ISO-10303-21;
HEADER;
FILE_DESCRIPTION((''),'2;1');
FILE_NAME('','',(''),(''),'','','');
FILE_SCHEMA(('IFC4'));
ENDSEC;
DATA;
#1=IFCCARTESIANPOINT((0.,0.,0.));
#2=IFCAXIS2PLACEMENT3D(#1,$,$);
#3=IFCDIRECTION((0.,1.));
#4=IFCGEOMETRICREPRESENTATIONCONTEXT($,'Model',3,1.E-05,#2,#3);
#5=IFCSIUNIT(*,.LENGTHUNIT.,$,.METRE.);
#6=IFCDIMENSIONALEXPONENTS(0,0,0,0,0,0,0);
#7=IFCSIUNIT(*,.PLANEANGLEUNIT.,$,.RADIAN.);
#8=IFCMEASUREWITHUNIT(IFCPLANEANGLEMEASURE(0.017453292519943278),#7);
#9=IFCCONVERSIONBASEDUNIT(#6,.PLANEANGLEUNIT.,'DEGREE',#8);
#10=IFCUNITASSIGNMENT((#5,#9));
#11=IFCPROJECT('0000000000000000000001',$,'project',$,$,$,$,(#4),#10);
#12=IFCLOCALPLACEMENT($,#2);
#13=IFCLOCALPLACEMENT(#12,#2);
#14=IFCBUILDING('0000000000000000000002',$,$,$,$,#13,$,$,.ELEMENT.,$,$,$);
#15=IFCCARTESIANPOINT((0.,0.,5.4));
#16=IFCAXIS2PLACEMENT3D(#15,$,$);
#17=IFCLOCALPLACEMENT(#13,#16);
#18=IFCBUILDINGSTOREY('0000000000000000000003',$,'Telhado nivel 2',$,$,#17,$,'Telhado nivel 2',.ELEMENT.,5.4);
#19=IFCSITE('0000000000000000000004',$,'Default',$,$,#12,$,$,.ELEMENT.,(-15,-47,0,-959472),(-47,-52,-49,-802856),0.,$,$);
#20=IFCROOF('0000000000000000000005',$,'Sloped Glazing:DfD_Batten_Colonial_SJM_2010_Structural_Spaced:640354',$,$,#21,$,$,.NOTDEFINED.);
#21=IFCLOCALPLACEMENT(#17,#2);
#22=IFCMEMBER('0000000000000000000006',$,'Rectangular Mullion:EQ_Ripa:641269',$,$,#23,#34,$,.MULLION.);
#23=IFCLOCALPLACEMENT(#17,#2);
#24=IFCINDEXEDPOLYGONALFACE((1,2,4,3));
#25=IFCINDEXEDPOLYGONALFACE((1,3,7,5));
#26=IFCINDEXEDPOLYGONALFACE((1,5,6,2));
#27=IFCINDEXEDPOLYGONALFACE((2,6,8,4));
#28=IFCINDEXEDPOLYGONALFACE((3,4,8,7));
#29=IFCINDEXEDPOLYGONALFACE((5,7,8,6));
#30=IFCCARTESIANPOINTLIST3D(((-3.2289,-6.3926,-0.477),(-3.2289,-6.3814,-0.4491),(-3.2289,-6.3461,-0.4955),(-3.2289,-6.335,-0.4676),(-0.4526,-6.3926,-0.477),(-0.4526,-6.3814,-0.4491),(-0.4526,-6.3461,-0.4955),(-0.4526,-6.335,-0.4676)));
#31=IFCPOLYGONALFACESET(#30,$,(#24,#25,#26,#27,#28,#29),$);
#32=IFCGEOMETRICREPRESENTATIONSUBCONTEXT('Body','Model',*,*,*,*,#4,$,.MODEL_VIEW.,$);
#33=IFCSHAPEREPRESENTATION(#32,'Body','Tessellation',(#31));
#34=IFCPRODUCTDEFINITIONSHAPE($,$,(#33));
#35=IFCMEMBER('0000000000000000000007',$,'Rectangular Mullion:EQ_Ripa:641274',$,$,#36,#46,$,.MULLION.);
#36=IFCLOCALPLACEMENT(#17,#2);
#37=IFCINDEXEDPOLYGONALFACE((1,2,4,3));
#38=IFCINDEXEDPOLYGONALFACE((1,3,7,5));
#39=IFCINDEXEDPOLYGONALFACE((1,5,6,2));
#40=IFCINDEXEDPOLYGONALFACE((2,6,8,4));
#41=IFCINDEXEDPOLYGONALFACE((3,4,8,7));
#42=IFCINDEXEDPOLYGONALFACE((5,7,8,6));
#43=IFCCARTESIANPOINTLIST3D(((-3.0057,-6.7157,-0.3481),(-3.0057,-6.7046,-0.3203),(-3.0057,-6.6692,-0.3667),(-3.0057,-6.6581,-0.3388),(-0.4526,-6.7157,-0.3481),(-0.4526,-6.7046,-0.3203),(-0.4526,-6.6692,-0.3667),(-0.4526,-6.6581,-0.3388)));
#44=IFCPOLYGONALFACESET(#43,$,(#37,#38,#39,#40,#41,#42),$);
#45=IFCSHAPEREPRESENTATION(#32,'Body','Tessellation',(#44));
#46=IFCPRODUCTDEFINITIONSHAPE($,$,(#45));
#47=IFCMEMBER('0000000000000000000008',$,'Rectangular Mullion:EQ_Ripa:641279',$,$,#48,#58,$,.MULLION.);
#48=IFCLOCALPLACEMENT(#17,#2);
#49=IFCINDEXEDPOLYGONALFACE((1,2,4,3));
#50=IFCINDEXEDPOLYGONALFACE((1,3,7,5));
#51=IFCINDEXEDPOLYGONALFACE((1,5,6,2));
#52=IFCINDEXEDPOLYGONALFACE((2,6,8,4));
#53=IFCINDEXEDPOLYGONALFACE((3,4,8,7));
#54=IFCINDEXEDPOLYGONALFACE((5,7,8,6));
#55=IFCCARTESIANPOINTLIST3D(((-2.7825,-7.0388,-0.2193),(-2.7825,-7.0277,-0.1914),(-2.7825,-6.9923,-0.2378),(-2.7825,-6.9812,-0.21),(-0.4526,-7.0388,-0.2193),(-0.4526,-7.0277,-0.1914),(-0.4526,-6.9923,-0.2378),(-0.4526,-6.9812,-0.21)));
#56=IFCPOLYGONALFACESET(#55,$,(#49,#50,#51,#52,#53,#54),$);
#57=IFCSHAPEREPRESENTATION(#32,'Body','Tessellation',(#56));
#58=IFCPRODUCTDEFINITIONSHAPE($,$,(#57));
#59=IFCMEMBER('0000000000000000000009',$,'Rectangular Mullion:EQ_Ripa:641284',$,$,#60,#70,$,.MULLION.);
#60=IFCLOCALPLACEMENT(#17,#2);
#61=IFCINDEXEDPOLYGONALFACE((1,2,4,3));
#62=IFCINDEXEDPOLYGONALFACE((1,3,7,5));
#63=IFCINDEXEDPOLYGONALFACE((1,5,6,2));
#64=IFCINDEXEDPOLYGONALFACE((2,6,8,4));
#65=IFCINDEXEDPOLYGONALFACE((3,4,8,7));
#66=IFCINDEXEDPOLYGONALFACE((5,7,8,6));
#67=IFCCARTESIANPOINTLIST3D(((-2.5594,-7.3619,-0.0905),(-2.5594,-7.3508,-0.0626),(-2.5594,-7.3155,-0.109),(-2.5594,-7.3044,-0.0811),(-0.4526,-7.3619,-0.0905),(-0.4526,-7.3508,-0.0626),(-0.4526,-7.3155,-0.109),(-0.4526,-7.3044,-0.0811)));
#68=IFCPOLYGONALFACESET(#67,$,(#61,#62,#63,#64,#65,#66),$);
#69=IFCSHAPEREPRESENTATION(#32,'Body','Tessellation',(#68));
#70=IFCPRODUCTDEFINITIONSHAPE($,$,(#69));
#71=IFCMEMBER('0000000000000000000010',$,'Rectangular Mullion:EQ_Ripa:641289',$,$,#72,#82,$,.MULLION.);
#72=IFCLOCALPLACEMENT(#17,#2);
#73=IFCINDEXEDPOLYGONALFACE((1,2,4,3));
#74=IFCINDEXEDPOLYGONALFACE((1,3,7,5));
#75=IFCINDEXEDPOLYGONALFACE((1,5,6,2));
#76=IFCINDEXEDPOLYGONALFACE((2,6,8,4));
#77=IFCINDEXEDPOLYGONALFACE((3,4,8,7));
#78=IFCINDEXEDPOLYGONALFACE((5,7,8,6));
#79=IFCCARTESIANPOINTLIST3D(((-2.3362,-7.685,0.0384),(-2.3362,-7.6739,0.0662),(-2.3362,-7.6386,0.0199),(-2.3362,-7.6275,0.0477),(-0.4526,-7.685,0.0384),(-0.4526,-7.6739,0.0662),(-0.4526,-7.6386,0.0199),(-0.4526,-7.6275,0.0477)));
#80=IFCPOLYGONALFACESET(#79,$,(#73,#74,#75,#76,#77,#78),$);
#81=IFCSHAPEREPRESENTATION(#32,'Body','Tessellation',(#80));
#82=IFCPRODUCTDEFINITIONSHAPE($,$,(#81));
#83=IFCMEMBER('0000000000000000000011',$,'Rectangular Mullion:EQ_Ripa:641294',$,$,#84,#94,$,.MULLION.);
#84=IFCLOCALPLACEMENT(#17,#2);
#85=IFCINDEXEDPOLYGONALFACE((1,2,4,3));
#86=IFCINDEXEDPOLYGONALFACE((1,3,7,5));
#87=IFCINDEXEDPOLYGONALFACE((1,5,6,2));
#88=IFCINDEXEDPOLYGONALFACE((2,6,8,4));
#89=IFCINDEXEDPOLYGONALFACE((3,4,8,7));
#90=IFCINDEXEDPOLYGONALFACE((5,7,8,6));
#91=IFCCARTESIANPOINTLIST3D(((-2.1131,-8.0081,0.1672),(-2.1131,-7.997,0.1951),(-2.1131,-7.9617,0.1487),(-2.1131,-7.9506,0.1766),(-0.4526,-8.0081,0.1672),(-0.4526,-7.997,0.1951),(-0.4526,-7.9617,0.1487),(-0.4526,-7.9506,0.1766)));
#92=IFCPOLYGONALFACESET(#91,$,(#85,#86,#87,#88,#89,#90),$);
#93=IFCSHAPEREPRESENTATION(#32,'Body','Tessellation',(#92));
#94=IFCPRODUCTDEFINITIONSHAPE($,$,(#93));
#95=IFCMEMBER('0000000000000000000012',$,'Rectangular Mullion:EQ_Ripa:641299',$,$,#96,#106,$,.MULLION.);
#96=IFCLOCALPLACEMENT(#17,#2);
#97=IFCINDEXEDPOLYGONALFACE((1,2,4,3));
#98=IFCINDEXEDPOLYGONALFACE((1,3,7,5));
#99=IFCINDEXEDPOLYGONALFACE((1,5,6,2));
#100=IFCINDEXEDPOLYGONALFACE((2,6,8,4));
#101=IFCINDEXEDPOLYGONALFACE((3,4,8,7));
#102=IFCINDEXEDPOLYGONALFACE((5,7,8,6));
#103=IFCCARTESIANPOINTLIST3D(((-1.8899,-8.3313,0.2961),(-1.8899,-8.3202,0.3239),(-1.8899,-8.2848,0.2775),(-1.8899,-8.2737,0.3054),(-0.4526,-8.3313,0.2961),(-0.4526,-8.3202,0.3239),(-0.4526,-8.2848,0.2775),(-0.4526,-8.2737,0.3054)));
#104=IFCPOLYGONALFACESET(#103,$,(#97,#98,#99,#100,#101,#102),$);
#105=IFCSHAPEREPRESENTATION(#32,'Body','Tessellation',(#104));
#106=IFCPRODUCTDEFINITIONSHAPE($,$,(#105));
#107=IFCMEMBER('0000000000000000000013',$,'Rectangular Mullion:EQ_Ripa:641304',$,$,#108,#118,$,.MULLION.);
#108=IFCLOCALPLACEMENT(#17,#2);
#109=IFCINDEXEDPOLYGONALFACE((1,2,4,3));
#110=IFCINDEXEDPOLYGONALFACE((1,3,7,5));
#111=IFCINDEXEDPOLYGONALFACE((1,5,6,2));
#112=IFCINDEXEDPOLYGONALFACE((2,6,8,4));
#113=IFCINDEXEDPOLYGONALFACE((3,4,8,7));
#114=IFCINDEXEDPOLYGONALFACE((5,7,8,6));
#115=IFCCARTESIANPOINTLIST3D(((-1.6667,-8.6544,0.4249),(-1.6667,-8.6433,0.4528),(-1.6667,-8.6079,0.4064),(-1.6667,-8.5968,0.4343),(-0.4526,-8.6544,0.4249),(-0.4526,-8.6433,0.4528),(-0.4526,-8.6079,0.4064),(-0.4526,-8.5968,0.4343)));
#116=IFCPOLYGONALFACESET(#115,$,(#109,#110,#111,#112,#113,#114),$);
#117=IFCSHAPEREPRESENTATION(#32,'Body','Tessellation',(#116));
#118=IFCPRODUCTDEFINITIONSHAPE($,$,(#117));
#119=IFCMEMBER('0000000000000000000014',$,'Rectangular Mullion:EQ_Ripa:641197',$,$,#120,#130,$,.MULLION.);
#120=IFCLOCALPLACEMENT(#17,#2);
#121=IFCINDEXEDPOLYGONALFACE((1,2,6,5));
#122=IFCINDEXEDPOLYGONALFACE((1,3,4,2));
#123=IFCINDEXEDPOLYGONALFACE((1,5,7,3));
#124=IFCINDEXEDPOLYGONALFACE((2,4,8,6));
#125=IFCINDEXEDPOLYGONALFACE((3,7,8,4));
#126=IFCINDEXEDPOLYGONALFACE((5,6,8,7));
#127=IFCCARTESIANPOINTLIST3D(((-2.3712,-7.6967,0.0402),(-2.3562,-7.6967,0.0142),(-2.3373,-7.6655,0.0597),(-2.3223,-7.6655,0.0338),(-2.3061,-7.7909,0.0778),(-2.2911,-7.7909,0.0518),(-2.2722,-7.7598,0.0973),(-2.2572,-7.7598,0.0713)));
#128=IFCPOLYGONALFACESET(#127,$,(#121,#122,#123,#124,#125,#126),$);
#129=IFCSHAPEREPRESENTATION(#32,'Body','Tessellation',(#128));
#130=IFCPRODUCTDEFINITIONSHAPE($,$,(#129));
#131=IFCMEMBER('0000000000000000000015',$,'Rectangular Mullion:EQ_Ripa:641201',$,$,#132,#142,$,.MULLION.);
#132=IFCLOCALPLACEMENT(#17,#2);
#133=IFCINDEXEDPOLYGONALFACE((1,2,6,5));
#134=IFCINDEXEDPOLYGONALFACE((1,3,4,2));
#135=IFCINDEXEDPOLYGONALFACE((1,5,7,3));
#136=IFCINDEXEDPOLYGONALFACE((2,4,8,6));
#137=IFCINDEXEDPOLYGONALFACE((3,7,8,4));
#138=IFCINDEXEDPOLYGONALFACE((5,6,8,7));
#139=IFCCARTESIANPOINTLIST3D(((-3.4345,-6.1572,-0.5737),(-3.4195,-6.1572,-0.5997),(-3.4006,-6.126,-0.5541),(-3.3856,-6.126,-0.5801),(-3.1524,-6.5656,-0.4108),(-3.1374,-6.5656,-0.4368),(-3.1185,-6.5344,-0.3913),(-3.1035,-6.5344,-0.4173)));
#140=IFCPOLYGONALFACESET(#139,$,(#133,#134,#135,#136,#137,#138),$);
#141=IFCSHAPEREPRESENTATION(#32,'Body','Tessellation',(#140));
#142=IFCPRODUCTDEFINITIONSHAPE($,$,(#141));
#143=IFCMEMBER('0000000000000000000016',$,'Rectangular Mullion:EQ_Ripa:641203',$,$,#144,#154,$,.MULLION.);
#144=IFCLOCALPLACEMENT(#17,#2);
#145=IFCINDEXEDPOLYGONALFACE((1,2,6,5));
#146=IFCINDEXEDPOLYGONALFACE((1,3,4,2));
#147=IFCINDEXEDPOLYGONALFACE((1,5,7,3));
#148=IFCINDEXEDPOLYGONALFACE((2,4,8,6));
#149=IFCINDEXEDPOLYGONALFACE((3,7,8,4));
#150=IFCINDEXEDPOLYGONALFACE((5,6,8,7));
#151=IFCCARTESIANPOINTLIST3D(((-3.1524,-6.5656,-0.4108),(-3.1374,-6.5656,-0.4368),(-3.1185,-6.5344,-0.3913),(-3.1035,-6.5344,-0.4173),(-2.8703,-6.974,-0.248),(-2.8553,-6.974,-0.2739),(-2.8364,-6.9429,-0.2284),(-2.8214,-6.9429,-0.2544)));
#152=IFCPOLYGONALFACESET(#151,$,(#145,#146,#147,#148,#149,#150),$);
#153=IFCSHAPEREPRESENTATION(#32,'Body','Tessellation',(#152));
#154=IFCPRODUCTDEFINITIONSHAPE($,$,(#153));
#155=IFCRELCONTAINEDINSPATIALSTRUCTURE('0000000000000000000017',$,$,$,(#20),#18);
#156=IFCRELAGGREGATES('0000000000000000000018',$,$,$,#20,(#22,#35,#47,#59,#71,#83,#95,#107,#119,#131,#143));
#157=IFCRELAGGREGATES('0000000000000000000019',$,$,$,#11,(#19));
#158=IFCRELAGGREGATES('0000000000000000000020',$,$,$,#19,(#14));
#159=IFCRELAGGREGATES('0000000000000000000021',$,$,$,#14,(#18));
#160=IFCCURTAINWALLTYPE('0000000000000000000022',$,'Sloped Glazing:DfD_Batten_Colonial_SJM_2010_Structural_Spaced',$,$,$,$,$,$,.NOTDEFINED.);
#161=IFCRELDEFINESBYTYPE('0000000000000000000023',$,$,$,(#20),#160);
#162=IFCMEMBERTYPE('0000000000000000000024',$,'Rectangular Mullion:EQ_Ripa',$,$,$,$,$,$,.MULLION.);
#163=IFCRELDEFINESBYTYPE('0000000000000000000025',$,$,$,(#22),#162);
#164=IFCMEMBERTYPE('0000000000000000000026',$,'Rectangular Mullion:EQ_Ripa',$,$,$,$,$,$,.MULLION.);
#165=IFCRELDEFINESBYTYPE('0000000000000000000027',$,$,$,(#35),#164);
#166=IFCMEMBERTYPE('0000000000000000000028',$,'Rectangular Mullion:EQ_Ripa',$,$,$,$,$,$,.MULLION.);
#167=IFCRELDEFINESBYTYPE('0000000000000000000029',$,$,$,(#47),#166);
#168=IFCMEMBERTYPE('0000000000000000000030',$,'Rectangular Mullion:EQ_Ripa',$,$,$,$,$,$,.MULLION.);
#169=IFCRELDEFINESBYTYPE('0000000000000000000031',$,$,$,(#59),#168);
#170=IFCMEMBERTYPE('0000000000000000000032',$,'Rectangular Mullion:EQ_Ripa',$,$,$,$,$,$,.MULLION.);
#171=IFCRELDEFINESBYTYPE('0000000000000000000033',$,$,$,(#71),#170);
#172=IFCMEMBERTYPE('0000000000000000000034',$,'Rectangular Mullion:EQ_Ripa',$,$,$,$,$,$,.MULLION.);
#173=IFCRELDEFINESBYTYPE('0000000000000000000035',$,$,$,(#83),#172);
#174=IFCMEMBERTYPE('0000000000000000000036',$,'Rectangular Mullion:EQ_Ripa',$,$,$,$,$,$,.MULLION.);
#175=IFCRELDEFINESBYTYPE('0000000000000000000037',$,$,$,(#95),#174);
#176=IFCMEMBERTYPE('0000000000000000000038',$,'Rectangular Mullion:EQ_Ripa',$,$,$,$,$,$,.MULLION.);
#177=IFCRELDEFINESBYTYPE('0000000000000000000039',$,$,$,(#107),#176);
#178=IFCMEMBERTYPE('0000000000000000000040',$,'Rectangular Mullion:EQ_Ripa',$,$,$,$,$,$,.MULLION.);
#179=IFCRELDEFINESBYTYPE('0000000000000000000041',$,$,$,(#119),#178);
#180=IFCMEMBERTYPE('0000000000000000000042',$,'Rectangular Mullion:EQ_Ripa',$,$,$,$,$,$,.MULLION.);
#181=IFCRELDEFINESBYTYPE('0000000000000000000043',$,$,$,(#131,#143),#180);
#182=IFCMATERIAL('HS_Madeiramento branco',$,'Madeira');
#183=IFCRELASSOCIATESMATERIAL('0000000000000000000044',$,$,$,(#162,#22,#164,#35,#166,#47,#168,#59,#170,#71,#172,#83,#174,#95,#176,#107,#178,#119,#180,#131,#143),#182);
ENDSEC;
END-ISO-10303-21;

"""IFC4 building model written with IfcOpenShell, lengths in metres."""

from ifc_helpers import new_model, entity, si_unit, converted_unit, direction, frame, origin, place, context, subcontext, project, spatial, indexed_curve, outline, extrude, source, transform, mapped, material, type_object, type_shapes, element, aggregate, save


model = new_model("IFC4")

# Units and contexts
model_context = context("Model", 3, precision=1e-05, world=origin(), true_north=direction((0.0, 1.0)))
body_context = subcontext(model_context, "Body", "Model", "MODEL_VIEW")
ifc_project = project(units=[si_unit("LENGTHUNIT", "METRE"), converted_unit("PLANEANGLEUNIT", "DEGREE", entity("IfcPlaneAngleMeasure", 0.017453292519943278), si_unit("PLANEANGLEUNIT", "RADIAN"), dimensions=[0, 0, 0, 0, 0, 0, 0])], contexts=[model_context])

# Site, building, storey
site_placement = place(None, origin())
site = spatial("IfcSite", under=ifc_project, at=site_placement, Name="Default", CompositionType="ELEMENT", RefLatitude=(-15, -47, 0, -959472), RefLongitude=(-47, -52, -49, -802856), RefElevation=0.0)
building_placement = place(site_placement, origin())
building = spatial("IfcBuilding", under=site, at=building_placement, CompositionType="ELEMENT")
storey_placement = place(building_placement, frame((0.0, 0.0, 5.4)))
storey = spatial("IfcBuildingStorey", under=building, at=storey_placement, Name="Telhado nivel 2", LongName="Telhado nivel 2", CompositionType="ELEMENT", Elevation=5.4)

# Roof, members
curtain_wall_type = type_object("IfcCurtainWallType", Name="Sloped Glazing:DfD_Batten_Colonial_SJM_2010_Structural_Spaced", PredefinedType="NOTDEFINED")
roof_placement = place(storey_placement, frame((0.0, 0.0, -5.4)))
roof = element("IfcRoof", 1, at=roof_placement, inside=storey, type_object=curtain_wall_type, Name="Sloped Glazing:DfD_Batten_Colonial_SJM_2010_Structural_Spaced:640354", PredefinedType="NOTDEFINED")
ifc_material = material(Name="HS_Madeiramento branco", Category="Madeira")
member_type_1 = type_object("IfcMemberType", Name="Rectangular Mullion:EQ_Ripa", PredefinedType="MULLION", material=ifc_material)
shared_shape_1 = source(origin(), body_context, "Body", "SweptSolid", [
    extrude(outline(indexed_curve([(-0.025, -0.015), (0.025, -0.015), (0.025, 0.015), (-0.025, 0.015), (-0.025, -0.015)], self_intersect=False)), frame((0.0, 0.0, -2.7763), z_axis=(0.0, 0.0, 1.0), x_axis=(-1.0, 0.0, 0.0)), (0.0, 0.0, 1.0), 2.7763),
])
type_shapes(member_type_1, [shared_shape_1])
member_1_placement = place(roof_placement, frame((-0.4526, -6.3638, 4.9277), z_axis=(1.0, 0.0, 0.0), x_axis=(0.0, -0.928878, 0.370385)))
member_1 = element("IfcMember", 2, at=member_1_placement, type_object=member_type_1, material=ifc_material, Name="Rectangular Mullion:EQ_Ripa:641269", PredefinedType="MULLION", context=body_context, shape_type="MappedRepresentation", body=[
    mapped(shared_shape_1, transform((0.0, 0.0, 0.0), scale=1.0)),
])
member_type_2 = type_object("IfcMemberType", Name="Rectangular Mullion:EQ_Ripa", PredefinedType="MULLION", material=ifc_material)
shared_shape_2 = source(origin(), body_context, "Body", "SweptSolid", [
    extrude(outline(indexed_curve([(-0.025, -0.015), (0.025, -0.015), (0.025, 0.015), (-0.025, 0.015), (-0.025, -0.015)], self_intersect=False)), frame((0.0, 0.0, -2.5531), z_axis=(0.0, 0.0, 1.0), x_axis=(-1.0, 0.0, 0.0)), (0.0, 0.0, 1.0), 2.5531),
])
type_shapes(member_type_2, [shared_shape_2])
member_2_placement = place(roof_placement, frame((-0.4526, -6.6869, 5.0565), z_axis=(1.0, 0.0, 0.0), x_axis=(0.0, -0.928878, 0.370385)))
member_2 = element("IfcMember", 3, at=member_2_placement, type_object=member_type_2, material=ifc_material, Name="Rectangular Mullion:EQ_Ripa:641274", PredefinedType="MULLION", context=body_context, shape_type="MappedRepresentation", body=[
    mapped(shared_shape_2, transform((0.0, 0.0, 0.0), scale=1.0)),
])
member_type_3 = type_object("IfcMemberType", Name="Rectangular Mullion:EQ_Ripa", PredefinedType="MULLION", material=ifc_material)
shared_shape_3 = source(origin(), body_context, "Body", "SweptSolid", [
    extrude(outline(indexed_curve([(-0.025, -0.015), (0.025, -0.015), (0.025, 0.015), (-0.025, 0.015), (-0.025, -0.015)], self_intersect=False)), frame((0.0, 0.0, -2.3299), z_axis=(0.0, 0.0, 1.0), x_axis=(-1.0, 0.0, 0.0)), (0.0, 0.0, 1.0), 2.3299),
])
type_shapes(member_type_3, [shared_shape_3])
member_3_placement = place(roof_placement, frame((-0.4526, -7.01, 5.1854), z_axis=(1.0, 0.0, 0.0), x_axis=(0.0, -0.928878, 0.370385)))
member_3 = element("IfcMember", 4, at=member_3_placement, type_object=member_type_3, material=ifc_material, Name="Rectangular Mullion:EQ_Ripa:641279", PredefinedType="MULLION", context=body_context, shape_type="MappedRepresentation", body=[
    mapped(shared_shape_3, transform((0.0, 0.0, 0.0), scale=1.0)),
])
member_type_4 = type_object("IfcMemberType", Name="Rectangular Mullion:EQ_Ripa", PredefinedType="MULLION", material=ifc_material)
shared_shape_4 = source(origin(), body_context, "Body", "SweptSolid", [
    extrude(outline(indexed_curve([(-0.025, -0.015), (0.025, -0.015), (0.025, 0.015), (-0.025, 0.015), (-0.025, -0.015)], self_intersect=False)), frame((0.0, 0.0, -2.1068), z_axis=(0.0, 0.0, 1.0), x_axis=(-1.0, 0.0, 0.0)), (0.0, 0.0, 1.0), 2.1068),
])
type_shapes(member_type_4, [shared_shape_4])
member_4_placement = place(roof_placement, frame((-0.4526, -7.3331, 5.3142), z_axis=(1.0, 0.0, 0.0), x_axis=(0.0, -0.928878, 0.370385)))
member_4 = element("IfcMember", 5, at=member_4_placement, type_object=member_type_4, material=ifc_material, Name="Rectangular Mullion:EQ_Ripa:641284", PredefinedType="MULLION", context=body_context, shape_type="MappedRepresentation", body=[
    mapped(shared_shape_4, transform((0.0, 0.0, 0.0), scale=1.0)),
])
member_type_5 = type_object("IfcMemberType", Name="Rectangular Mullion:EQ_Ripa", PredefinedType="MULLION", material=ifc_material)
shared_shape_5 = source(origin(), body_context, "Body", "SweptSolid", [
    extrude(outline(indexed_curve([(-0.025, -0.015), (0.025, -0.015), (0.025, 0.015), (-0.025, 0.015), (-0.025, -0.015)], self_intersect=False)), frame((0.0, 0.0, -1.8836), z_axis=(0.0, 0.0, 1.0), x_axis=(-1.0, 0.0, 0.0)), (0.0, 0.0, 1.0), 1.8836),
])
type_shapes(member_type_5, [shared_shape_5])
member_5_placement = place(roof_placement, frame((-0.4526, -7.6562, 5.4431), z_axis=(1.0, 0.0, 0.0), x_axis=(0.0, -0.928878, 0.370385)))
member_5 = element("IfcMember", 6, at=member_5_placement, type_object=member_type_5, material=ifc_material, Name="Rectangular Mullion:EQ_Ripa:641289", PredefinedType="MULLION", context=body_context, shape_type="MappedRepresentation", body=[
    mapped(shared_shape_5, transform((0.0, 0.0, 0.0), scale=1.0)),
])
member_type_6 = type_object("IfcMemberType", Name="Rectangular Mullion:EQ_Ripa", PredefinedType="MULLION", material=ifc_material)
shared_shape_6 = source(origin(), body_context, "Body", "SweptSolid", [
    extrude(outline(indexed_curve([(-0.025, -0.015), (0.025, -0.015), (0.025, 0.015), (-0.025, 0.015), (-0.025, -0.015)], self_intersect=False)), frame((0.0, 0.0, -1.6605), z_axis=(0.0, 0.0, 1.0), x_axis=(-1.0, 0.0, 0.0)), (0.0, 0.0, 1.0), 1.6605),
])
type_shapes(member_type_6, [shared_shape_6])
member_6_placement = place(roof_placement, frame((-0.4526, -7.9794, 5.5719), z_axis=(1.0, 0.0, 0.0), x_axis=(0.0, -0.928878, 0.370385)))
member_6 = element("IfcMember", 7, at=member_6_placement, type_object=member_type_6, material=ifc_material, Name="Rectangular Mullion:EQ_Ripa:641294", PredefinedType="MULLION", context=body_context, shape_type="MappedRepresentation", body=[
    mapped(shared_shape_6, transform((0.0, 0.0, 0.0), scale=1.0)),
])
member_type_7 = type_object("IfcMemberType", Name="Rectangular Mullion:EQ_Ripa", PredefinedType="MULLION", material=ifc_material)
shared_shape_7 = source(origin(), body_context, "Body", "SweptSolid", [
    extrude(outline(indexed_curve([(-0.025, -0.015), (0.025, -0.015), (0.025, 0.015), (-0.025, 0.015), (-0.025, -0.015)], self_intersect=False)), frame((0.0, 0.0, -1.4373), z_axis=(0.0, 0.0, 1.0), x_axis=(-1.0, 0.0, 0.0)), (0.0, 0.0, 1.0), 1.4373),
])
type_shapes(member_type_7, [shared_shape_7])
member_7_placement = place(roof_placement, frame((-0.4526, -8.3025, 5.7007), z_axis=(1.0, 0.0, 0.0), x_axis=(0.0, -0.928878, 0.370385)))
member_7 = element("IfcMember", 8, at=member_7_placement, type_object=member_type_7, material=ifc_material, Name="Rectangular Mullion:EQ_Ripa:641299", PredefinedType="MULLION", context=body_context, shape_type="MappedRepresentation", body=[
    mapped(shared_shape_7, transform((0.0, 0.0, 0.0), scale=1.0)),
])
member_type_8 = type_object("IfcMemberType", Name="Rectangular Mullion:EQ_Ripa", PredefinedType="MULLION", material=ifc_material)
shared_shape_8 = source(origin(), body_context, "Body", "SweptSolid", [
    extrude(outline(indexed_curve([(-0.025, -0.015), (0.025, -0.015), (0.025, 0.015), (-0.025, 0.015), (-0.025, -0.015)], self_intersect=False)), frame((0.0, 0.0, -1.2141), z_axis=(0.0, 0.0, 1.0), x_axis=(-1.0, 0.0, 0.0)), (0.0, 0.0, 1.0), 1.2141),
])
type_shapes(member_type_8, [shared_shape_8])
member_8_placement = place(roof_placement, frame((-0.4526, -8.6256, 5.8296), z_axis=(1.0, 0.0, 0.0), x_axis=(0.0, -0.928878, 0.370385)))
member_8 = element("IfcMember", 9, at=member_8_placement, type_object=member_type_8, material=ifc_material, Name="Rectangular Mullion:EQ_Ripa:641304", PredefinedType="MULLION", context=body_context, shape_type="MappedRepresentation", body=[
    mapped(shared_shape_8, transform((0.0, 0.0, 0.0), scale=1.0)),
])
member_type_9 = type_object("IfcMemberType", Name="Rectangular Mullion:EQ_Ripa", PredefinedType="MULLION", material=ifc_material)
shared_shape_9 = source(origin(), body_context, "Body", "SweptSolid", [
    extrude(outline(indexed_curve([(-0.025, -0.015), (0.025, -0.015), (0.025, 0.015), (-0.025, 0.015), (-0.025, -0.015)], self_intersect=False)), frame((-0.025, 0.0, -0.1205), z_axis=(0.0, 0.0, 1.0), x_axis=(-1.0, 0.0, 0.0)), (0.0, 0.0, 1.0), 0.1205),
])
type_shapes(member_type_9, [shared_shape_9])
member_9_placement = place(roof_placement, frame((-2.3298, -7.6655, 5.4468), z_axis=(-0.539965, 0.781825, -0.311749), x_axis=(0.67708, 0.623498, 0.390913)))
member_9 = element("IfcMember", 10, at=member_9_placement, type_object=member_type_9, material=ifc_material, Name="Rectangular Mullion:EQ_Ripa:641197", PredefinedType="MULLION", context=body_context, shape_type="MappedRepresentation", body=[
    mapped(shared_shape_9, transform((0.0, 0.0, 0.0), scale=1.0)),
])
member_type_10 = type_object("IfcMemberType", Name="Rectangular Mullion:EQ_Ripa", PredefinedType="MULLION", material=ifc_material)
shared_shape_10 = source(origin(), body_context, "Body", "SweptSolid", [
    extrude(outline(indexed_curve([(-0.025, -0.015), (0.025, -0.015), (0.025, 0.015), (-0.025, 0.015), (-0.025, -0.015)], self_intersect=False)), frame((-0.025, 0.0, -0.5224), z_axis=(0.0, 0.0, 1.0), x_axis=(-1.0, 0.0, 0.0)), (0.0, 0.0, 1.0), 0.5224),
])
type_shapes(member_type_10, [shared_shape_10])
member_10_placement = place(roof_placement, frame((-3.3931, -6.126, 4.8329), z_axis=(-0.539965, 0.781825, -0.311749), x_axis=(0.67708, 0.623498, 0.390913)))
member_10 = element("IfcMember", 11, at=member_10_placement, type_object=member_type_10, material=ifc_material, Name="Rectangular Mullion:EQ_Ripa:641201", PredefinedType="MULLION", context=body_context, shape_type="MappedRepresentation", body=[
    mapped(shared_shape_10, transform((0.0, 0.0, 0.0), scale=1.0)),
])
member_11_placement = place(roof_placement, frame((-3.111, -6.5344, 4.9957), z_axis=(-0.539965, 0.781825, -0.311749), x_axis=(0.67708, 0.623498, 0.390913)))
member_11 = element("IfcMember", 12, at=member_11_placement, type_object=member_type_10, material=ifc_material, Name="Rectangular Mullion:EQ_Ripa:641203", PredefinedType="MULLION", context=body_context, shape_type="MappedRepresentation", body=[
    mapped(shared_shape_10, transform((0.0, 0.0, 0.0), scale=1.0)),
])
aggregate(roof, [member_1, member_2, member_3, member_4, member_5, member_6, member_7, member_8, member_9, member_10, member_11])

save(model, "model.ifc")
